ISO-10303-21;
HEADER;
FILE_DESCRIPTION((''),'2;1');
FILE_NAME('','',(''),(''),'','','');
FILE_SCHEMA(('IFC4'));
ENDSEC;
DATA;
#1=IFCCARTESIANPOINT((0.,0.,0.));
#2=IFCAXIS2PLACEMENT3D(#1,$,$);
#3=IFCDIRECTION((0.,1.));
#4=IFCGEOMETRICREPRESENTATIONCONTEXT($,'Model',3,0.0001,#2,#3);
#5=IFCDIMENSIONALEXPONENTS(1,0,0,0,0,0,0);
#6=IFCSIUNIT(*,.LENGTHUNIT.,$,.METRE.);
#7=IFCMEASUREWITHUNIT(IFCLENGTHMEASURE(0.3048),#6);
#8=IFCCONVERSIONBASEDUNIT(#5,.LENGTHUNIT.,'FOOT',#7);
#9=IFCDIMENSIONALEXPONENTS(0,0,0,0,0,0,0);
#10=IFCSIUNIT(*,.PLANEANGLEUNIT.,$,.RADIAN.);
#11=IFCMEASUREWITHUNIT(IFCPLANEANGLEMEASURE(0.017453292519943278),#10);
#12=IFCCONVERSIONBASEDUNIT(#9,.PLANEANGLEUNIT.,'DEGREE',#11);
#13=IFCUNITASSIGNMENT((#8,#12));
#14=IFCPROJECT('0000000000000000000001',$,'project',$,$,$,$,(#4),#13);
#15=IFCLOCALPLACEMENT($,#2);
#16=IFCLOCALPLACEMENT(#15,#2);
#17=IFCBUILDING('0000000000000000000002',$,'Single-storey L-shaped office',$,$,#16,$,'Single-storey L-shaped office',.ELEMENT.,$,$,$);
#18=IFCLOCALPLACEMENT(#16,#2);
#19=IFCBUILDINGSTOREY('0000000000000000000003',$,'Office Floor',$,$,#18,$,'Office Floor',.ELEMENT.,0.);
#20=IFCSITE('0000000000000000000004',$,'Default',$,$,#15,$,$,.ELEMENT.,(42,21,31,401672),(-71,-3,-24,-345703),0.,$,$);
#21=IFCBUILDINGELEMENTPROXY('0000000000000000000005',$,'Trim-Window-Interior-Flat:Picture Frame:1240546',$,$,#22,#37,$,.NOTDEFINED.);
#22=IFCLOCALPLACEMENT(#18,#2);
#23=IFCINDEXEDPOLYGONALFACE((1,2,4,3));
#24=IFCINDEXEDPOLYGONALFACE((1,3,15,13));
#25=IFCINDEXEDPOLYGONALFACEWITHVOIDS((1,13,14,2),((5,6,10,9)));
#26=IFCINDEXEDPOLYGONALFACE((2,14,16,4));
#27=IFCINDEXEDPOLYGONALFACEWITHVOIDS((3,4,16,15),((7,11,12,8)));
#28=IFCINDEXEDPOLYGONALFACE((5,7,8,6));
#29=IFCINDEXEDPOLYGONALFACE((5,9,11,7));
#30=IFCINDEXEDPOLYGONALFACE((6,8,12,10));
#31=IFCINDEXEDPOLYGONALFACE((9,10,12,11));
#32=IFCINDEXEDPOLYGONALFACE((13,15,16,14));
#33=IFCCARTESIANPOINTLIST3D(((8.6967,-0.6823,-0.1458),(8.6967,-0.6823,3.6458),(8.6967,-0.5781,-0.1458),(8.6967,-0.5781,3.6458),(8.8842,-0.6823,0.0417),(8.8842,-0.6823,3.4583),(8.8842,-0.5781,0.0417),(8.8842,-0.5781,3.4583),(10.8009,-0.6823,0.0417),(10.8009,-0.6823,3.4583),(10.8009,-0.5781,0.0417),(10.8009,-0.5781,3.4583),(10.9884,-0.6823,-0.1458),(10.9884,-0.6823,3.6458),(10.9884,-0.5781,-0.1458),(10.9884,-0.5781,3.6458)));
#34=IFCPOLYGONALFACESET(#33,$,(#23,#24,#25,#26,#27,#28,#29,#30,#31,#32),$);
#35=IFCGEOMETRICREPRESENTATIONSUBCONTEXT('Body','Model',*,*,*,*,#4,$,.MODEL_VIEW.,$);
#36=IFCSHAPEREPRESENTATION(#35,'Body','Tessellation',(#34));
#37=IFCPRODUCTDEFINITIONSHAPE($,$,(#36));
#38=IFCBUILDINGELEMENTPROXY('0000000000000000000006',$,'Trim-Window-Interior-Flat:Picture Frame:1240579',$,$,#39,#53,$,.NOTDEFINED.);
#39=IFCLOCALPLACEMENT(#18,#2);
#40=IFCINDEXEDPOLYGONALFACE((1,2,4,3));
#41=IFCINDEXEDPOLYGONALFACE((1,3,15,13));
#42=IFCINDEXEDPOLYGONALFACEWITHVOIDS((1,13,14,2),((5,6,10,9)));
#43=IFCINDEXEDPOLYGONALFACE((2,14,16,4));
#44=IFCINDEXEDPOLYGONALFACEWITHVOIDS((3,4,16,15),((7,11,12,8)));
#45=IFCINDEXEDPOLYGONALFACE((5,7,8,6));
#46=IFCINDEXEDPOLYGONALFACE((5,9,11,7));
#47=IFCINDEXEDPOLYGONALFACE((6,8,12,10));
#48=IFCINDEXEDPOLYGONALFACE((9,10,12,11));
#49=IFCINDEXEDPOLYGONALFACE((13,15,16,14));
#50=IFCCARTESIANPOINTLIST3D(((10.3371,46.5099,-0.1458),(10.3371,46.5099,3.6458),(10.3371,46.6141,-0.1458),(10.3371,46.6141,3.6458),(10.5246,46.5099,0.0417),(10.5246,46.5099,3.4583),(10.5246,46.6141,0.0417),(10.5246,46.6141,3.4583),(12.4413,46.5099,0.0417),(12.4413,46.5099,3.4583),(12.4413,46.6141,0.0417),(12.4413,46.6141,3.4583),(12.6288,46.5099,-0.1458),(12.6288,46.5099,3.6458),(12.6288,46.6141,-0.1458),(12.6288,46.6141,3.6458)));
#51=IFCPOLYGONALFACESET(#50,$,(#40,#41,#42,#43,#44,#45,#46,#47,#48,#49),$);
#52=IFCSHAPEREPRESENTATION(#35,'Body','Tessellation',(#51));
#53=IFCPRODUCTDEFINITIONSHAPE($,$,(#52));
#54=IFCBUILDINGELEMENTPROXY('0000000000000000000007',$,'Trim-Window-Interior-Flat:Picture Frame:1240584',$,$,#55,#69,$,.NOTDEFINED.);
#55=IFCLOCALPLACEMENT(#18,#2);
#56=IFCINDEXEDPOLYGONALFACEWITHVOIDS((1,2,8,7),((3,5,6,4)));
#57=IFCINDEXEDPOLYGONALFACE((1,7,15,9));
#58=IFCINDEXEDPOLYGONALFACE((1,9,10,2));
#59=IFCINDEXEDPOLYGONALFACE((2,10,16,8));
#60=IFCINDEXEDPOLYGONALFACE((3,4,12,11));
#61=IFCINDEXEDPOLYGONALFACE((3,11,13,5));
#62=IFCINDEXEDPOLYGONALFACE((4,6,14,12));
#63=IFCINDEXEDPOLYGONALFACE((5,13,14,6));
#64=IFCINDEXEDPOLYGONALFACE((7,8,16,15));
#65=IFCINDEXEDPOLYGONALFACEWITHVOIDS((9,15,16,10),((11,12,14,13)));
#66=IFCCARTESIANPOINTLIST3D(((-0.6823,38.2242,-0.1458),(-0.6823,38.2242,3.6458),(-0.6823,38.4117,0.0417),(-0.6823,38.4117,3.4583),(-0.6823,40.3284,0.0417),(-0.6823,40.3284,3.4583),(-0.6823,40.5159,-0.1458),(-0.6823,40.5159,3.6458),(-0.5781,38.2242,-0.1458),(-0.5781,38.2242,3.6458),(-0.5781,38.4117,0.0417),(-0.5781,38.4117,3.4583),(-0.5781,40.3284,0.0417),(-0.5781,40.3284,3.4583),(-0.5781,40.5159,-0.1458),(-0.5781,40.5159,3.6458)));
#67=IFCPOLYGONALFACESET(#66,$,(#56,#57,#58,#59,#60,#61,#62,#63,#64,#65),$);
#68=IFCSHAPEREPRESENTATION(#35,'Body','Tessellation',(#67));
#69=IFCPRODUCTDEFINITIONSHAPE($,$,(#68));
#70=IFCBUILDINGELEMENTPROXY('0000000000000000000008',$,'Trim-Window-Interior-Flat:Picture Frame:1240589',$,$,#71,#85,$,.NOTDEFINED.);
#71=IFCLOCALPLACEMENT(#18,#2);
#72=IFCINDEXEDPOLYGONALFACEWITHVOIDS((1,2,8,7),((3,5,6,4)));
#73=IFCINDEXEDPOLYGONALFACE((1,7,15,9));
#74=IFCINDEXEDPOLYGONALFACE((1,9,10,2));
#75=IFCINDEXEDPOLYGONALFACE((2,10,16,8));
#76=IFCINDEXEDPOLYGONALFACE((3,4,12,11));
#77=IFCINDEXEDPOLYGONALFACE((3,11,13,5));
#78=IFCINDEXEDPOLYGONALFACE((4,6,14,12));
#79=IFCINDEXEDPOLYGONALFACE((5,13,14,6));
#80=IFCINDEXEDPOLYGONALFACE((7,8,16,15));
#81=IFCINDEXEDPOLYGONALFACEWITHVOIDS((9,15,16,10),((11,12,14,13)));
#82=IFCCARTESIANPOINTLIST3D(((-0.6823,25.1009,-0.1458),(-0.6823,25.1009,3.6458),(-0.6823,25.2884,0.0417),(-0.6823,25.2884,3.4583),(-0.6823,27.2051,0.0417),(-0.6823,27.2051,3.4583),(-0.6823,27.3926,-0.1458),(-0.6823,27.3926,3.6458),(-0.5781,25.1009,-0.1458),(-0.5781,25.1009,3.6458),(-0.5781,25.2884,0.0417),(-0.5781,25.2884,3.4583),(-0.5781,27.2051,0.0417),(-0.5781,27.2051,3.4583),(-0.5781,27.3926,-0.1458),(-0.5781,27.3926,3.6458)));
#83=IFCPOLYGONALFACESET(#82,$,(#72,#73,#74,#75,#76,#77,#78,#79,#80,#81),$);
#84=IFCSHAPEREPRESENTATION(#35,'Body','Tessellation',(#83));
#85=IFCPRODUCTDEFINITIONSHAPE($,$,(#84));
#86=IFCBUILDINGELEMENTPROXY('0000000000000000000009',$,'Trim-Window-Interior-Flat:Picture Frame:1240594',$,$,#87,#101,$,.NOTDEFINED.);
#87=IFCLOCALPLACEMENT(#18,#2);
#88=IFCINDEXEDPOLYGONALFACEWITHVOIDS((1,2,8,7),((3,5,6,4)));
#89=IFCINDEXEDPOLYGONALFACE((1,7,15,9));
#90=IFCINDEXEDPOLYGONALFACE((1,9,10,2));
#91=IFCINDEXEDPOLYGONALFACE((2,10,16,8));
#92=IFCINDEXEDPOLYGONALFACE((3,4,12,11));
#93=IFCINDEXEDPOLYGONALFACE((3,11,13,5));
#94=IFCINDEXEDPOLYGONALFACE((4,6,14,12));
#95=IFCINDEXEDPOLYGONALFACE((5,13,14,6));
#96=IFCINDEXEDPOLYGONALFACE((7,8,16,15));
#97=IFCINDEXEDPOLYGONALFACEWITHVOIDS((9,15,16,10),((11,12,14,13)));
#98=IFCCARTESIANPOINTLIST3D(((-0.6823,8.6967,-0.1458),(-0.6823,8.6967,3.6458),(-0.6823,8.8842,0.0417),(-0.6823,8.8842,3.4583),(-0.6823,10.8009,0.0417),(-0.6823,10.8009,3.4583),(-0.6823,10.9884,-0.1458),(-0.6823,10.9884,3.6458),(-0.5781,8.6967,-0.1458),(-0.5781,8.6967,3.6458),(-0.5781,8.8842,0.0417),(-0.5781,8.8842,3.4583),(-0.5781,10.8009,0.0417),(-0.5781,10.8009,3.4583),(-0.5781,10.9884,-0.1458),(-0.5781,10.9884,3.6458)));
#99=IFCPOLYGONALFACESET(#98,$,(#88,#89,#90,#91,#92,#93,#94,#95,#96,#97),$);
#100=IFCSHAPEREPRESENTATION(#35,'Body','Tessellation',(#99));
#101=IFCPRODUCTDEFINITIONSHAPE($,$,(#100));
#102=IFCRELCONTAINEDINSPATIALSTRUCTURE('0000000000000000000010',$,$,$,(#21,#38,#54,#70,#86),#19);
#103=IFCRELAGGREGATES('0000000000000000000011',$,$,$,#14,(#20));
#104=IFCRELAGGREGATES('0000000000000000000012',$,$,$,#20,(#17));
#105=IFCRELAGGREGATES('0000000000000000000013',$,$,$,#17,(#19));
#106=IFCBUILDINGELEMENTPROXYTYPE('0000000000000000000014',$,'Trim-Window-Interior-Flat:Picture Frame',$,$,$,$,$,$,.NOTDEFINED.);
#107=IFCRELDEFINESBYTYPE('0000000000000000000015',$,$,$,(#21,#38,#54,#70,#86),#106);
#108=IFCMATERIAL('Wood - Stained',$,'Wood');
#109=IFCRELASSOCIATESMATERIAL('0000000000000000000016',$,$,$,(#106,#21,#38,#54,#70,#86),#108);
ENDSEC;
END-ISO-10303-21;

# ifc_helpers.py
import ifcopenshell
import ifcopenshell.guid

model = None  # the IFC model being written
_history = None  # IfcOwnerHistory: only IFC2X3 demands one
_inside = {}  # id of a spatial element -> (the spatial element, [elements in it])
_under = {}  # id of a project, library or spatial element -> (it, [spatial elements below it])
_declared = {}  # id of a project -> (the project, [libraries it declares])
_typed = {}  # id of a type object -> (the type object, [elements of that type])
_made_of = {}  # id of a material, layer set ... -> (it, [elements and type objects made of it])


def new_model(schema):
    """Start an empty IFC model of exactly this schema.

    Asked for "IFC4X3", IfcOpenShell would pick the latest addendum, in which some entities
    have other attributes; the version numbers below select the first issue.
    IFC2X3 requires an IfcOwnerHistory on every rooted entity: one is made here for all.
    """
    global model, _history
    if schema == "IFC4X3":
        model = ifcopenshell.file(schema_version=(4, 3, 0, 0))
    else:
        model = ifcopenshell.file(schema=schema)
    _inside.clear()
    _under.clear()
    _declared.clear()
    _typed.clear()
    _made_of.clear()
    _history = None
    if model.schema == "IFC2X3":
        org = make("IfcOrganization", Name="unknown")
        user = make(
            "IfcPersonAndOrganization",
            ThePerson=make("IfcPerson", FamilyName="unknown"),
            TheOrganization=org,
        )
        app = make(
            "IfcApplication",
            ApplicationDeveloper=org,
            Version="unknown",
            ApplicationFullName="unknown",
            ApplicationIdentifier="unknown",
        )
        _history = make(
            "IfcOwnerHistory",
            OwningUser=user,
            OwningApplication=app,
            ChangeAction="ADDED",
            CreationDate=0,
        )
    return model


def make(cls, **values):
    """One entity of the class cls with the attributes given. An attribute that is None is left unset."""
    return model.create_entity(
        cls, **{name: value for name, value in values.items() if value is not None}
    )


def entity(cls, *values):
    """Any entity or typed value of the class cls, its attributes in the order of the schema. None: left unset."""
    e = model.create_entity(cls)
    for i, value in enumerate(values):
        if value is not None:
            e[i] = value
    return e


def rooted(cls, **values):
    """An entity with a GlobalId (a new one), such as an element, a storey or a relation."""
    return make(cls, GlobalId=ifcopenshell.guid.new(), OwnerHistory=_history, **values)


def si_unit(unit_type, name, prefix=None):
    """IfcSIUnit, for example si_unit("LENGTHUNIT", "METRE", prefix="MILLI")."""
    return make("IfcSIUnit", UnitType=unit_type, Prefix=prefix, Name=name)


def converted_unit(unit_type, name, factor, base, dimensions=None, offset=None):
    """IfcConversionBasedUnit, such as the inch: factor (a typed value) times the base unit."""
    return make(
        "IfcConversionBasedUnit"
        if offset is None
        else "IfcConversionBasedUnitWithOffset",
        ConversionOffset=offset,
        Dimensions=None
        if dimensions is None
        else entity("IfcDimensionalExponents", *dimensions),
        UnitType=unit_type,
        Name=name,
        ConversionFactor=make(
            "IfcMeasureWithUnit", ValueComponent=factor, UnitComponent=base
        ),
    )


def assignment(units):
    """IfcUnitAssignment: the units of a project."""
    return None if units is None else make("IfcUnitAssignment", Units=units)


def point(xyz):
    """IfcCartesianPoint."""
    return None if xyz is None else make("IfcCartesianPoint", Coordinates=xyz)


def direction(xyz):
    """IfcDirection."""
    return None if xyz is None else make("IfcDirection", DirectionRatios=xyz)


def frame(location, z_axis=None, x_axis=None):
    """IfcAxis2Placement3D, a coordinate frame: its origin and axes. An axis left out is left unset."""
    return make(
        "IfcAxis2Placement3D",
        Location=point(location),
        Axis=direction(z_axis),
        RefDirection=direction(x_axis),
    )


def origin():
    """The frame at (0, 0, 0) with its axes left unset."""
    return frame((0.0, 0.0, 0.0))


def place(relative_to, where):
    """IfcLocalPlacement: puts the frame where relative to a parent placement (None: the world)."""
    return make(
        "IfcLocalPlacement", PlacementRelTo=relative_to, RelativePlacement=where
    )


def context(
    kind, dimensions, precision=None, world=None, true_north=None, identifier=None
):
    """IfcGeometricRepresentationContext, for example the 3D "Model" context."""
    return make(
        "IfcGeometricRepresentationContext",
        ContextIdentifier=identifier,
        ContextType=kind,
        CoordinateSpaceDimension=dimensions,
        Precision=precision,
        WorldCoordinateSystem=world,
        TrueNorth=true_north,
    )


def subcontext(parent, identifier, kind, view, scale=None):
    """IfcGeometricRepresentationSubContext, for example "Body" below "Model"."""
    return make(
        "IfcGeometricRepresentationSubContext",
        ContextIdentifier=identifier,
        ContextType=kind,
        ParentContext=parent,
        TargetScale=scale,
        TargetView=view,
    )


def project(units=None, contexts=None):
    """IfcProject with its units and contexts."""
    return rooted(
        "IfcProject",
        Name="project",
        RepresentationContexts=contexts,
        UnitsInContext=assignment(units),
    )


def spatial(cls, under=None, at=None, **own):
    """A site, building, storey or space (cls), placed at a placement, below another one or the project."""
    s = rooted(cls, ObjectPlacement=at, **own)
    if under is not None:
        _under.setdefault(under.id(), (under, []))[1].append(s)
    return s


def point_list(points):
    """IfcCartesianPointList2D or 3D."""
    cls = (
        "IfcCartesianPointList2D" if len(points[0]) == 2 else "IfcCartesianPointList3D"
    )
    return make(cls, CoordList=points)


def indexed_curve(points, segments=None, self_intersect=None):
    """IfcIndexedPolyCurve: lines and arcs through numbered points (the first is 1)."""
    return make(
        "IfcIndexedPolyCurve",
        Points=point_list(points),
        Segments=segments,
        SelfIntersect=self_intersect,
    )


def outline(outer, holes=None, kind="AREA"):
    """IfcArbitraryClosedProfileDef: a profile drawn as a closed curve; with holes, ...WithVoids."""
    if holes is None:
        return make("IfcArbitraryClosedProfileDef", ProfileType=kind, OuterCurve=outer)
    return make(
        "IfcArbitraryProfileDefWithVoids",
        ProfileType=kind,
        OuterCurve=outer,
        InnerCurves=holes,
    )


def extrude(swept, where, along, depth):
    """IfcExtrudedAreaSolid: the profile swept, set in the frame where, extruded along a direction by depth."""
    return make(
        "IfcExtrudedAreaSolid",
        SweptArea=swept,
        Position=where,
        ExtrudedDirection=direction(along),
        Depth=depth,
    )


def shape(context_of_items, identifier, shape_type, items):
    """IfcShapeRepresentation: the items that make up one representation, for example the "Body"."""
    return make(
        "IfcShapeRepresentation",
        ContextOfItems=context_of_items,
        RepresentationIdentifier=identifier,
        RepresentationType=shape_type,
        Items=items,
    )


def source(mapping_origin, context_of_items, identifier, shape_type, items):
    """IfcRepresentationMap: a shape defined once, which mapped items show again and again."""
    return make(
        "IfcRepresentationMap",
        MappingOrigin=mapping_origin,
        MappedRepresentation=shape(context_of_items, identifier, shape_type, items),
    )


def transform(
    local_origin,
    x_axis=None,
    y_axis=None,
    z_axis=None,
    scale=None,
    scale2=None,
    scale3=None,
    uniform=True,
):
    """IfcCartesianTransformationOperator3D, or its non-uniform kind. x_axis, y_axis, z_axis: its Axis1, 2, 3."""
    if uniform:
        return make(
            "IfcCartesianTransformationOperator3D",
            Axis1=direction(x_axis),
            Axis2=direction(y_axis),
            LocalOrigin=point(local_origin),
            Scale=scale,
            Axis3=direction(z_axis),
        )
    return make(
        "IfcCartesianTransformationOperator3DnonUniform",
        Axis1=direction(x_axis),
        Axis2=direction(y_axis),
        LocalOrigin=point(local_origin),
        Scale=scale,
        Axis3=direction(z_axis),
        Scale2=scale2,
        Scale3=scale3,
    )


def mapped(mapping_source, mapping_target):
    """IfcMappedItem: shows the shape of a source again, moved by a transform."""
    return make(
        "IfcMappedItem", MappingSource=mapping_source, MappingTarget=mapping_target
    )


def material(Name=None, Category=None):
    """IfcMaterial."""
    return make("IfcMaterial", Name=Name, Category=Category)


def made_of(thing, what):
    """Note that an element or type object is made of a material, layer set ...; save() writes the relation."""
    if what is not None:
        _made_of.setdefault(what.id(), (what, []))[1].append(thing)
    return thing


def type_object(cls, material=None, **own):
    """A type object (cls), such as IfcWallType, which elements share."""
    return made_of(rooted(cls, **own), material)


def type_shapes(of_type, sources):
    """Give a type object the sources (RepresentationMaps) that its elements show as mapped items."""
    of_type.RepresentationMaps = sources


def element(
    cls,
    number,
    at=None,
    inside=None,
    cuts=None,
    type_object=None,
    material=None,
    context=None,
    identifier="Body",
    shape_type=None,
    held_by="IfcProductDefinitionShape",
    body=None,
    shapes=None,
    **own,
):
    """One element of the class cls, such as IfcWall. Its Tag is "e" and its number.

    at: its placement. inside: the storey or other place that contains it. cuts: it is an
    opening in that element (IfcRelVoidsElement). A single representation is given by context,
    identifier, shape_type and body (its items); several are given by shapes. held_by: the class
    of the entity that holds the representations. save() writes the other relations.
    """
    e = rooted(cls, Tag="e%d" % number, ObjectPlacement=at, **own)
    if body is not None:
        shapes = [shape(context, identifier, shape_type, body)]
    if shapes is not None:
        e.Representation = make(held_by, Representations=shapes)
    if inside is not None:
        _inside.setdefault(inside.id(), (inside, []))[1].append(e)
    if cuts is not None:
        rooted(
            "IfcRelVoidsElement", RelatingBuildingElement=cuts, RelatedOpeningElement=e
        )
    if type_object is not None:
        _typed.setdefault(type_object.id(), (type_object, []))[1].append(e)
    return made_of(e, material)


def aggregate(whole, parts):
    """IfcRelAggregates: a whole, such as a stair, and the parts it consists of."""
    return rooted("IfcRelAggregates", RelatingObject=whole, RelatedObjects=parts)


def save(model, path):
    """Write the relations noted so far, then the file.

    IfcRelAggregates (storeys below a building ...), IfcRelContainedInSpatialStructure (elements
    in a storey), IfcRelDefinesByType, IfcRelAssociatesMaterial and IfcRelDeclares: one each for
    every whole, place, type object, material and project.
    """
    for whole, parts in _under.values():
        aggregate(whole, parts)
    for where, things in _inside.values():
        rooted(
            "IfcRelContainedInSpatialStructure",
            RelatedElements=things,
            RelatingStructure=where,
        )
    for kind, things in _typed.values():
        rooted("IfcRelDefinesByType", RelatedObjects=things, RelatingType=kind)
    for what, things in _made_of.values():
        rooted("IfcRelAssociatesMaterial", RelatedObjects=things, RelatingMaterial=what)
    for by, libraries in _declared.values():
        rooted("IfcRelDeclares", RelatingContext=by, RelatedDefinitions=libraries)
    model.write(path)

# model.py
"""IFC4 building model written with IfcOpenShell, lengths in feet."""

from ifc_helpers import new_model, entity, si_unit, converted_unit, direction, frame, origin, place, context, subcontext, project, spatial, indexed_curve, outline, extrude, source, transform, mapped, material, type_object, type_shapes, element, save


model = new_model("IFC4")

# Units and contexts
model_context = context("Model", 3, precision=0.0001, world=origin(), true_north=direction((0.0, 1.0)))
body_context = subcontext(model_context, "Body", "Model", "MODEL_VIEW")
ifc_project = project(units=[converted_unit("LENGTHUNIT", "FOOT", entity("IfcLengthMeasure", 0.3048), si_unit("LENGTHUNIT", "METRE"), dimensions=[1, 0, 0, 0, 0, 0, 0]), converted_unit("PLANEANGLEUNIT", "DEGREE", entity("IfcPlaneAngleMeasure", 0.017453292519943278), si_unit("PLANEANGLEUNIT", "RADIAN"), dimensions=[0, 0, 0, 0, 0, 0, 0])], contexts=[model_context])

# Site, building, storey
site_placement = place(None, origin())
site = spatial("IfcSite", under=ifc_project, at=site_placement, Name="Default", CompositionType="ELEMENT", RefLatitude=(42, 21, 31, 401672), RefLongitude=(-71, -3, -24, -345703), RefElevation=0.0)
building_placement = place(site_placement, origin())
building = spatial("IfcBuilding", under=site, at=building_placement, Name="Single-storey L-shaped office", LongName="Single-storey L-shaped office", CompositionType="ELEMENT")
storey_placement = place(building_placement, origin())
storey = spatial("IfcBuildingStorey", under=building, at=storey_placement, Name="Office Floor", LongName="Office Floor", CompositionType="ELEMENT", Elevation=0.0)

# Shared definitions
ifc_material_1 = material(Name="Wood - Stained", Category="Wood")

# Building element proxies
building_element_proxy_type_1 = type_object("IfcBuildingElementProxyType", Name="Trim-Window-Interior-Flat:Picture Frame", PredefinedType="NOTDEFINED", material=ifc_material_1)
shared_shape_1 = source(origin(), body_context, "Body", "SweptSolid", [
    extrude(outline(indexed_curve([(-1.1458, -1.8958), (1.1458, -1.8958), (1.1458, 1.8958), (-1.1458, 1.8958), (-1.1458, -1.8958)], self_intersect=False), holes=[indexed_curve([(-0.9583, -1.7083), (-0.9583, 1.7083), (0.9583, 1.7083), (0.9583, -1.7083), (-0.9583, -1.7083)], self_intersect=False)]), frame((0.0, -1.75, 0.0), z_axis=(0.0, 0.0, 1.0), x_axis=(-1.0, 0.0, 0.0)), (0.0, 0.0, 1.0), 0.1042),
])
type_shapes(building_element_proxy_type_1, [shared_shape_1])
for number, where, z_axis, x_axis, name in (
    (1, (9.8425, -0.5781, 3.5), (0.0, -1.0, 0.0), (1.0, 0.0, 0.0), "Trim-Window-Interior-Flat:Picture Frame:1240546"),
    (2, (11.4829, 46.5099, 3.5), (0.0, 1.0, 0.0), (-1.0, 0.0, 0.0), "Trim-Window-Interior-Flat:Picture Frame:1240579"),
    (3, (-0.5781, 39.3701, 3.5), (-1.0, 0.0, 0.0), (0.0, -1.0, 0.0), "Trim-Window-Interior-Flat:Picture Frame:1240584"),
    (4, (-0.5781, 26.2467, 3.5), (-1.0, 0.0, 0.0), (0.0, -1.0, 0.0), "Trim-Window-Interior-Flat:Picture Frame:1240589"),
    (5, (-0.5781, 9.8425, 3.5), (-1.0, 0.0, 0.0), (0.0, -1.0, 0.0), "Trim-Window-Interior-Flat:Picture Frame:1240594"),
):
    element("IfcBuildingElementProxy", number, at=place(storey_placement, frame(where, z_axis=z_axis, x_axis=x_axis)), inside=storey, type_object=building_element_proxy_type_1, material=ifc_material_1, Name=name, PredefinedType="NOTDEFINED", context=body_context, shape_type="MappedRepresentation", body=[
        mapped(shared_shape_1, transform((0.0, 0.0, 0.0), scale=1.0)),
    ])

save(model, "model.ifc")
